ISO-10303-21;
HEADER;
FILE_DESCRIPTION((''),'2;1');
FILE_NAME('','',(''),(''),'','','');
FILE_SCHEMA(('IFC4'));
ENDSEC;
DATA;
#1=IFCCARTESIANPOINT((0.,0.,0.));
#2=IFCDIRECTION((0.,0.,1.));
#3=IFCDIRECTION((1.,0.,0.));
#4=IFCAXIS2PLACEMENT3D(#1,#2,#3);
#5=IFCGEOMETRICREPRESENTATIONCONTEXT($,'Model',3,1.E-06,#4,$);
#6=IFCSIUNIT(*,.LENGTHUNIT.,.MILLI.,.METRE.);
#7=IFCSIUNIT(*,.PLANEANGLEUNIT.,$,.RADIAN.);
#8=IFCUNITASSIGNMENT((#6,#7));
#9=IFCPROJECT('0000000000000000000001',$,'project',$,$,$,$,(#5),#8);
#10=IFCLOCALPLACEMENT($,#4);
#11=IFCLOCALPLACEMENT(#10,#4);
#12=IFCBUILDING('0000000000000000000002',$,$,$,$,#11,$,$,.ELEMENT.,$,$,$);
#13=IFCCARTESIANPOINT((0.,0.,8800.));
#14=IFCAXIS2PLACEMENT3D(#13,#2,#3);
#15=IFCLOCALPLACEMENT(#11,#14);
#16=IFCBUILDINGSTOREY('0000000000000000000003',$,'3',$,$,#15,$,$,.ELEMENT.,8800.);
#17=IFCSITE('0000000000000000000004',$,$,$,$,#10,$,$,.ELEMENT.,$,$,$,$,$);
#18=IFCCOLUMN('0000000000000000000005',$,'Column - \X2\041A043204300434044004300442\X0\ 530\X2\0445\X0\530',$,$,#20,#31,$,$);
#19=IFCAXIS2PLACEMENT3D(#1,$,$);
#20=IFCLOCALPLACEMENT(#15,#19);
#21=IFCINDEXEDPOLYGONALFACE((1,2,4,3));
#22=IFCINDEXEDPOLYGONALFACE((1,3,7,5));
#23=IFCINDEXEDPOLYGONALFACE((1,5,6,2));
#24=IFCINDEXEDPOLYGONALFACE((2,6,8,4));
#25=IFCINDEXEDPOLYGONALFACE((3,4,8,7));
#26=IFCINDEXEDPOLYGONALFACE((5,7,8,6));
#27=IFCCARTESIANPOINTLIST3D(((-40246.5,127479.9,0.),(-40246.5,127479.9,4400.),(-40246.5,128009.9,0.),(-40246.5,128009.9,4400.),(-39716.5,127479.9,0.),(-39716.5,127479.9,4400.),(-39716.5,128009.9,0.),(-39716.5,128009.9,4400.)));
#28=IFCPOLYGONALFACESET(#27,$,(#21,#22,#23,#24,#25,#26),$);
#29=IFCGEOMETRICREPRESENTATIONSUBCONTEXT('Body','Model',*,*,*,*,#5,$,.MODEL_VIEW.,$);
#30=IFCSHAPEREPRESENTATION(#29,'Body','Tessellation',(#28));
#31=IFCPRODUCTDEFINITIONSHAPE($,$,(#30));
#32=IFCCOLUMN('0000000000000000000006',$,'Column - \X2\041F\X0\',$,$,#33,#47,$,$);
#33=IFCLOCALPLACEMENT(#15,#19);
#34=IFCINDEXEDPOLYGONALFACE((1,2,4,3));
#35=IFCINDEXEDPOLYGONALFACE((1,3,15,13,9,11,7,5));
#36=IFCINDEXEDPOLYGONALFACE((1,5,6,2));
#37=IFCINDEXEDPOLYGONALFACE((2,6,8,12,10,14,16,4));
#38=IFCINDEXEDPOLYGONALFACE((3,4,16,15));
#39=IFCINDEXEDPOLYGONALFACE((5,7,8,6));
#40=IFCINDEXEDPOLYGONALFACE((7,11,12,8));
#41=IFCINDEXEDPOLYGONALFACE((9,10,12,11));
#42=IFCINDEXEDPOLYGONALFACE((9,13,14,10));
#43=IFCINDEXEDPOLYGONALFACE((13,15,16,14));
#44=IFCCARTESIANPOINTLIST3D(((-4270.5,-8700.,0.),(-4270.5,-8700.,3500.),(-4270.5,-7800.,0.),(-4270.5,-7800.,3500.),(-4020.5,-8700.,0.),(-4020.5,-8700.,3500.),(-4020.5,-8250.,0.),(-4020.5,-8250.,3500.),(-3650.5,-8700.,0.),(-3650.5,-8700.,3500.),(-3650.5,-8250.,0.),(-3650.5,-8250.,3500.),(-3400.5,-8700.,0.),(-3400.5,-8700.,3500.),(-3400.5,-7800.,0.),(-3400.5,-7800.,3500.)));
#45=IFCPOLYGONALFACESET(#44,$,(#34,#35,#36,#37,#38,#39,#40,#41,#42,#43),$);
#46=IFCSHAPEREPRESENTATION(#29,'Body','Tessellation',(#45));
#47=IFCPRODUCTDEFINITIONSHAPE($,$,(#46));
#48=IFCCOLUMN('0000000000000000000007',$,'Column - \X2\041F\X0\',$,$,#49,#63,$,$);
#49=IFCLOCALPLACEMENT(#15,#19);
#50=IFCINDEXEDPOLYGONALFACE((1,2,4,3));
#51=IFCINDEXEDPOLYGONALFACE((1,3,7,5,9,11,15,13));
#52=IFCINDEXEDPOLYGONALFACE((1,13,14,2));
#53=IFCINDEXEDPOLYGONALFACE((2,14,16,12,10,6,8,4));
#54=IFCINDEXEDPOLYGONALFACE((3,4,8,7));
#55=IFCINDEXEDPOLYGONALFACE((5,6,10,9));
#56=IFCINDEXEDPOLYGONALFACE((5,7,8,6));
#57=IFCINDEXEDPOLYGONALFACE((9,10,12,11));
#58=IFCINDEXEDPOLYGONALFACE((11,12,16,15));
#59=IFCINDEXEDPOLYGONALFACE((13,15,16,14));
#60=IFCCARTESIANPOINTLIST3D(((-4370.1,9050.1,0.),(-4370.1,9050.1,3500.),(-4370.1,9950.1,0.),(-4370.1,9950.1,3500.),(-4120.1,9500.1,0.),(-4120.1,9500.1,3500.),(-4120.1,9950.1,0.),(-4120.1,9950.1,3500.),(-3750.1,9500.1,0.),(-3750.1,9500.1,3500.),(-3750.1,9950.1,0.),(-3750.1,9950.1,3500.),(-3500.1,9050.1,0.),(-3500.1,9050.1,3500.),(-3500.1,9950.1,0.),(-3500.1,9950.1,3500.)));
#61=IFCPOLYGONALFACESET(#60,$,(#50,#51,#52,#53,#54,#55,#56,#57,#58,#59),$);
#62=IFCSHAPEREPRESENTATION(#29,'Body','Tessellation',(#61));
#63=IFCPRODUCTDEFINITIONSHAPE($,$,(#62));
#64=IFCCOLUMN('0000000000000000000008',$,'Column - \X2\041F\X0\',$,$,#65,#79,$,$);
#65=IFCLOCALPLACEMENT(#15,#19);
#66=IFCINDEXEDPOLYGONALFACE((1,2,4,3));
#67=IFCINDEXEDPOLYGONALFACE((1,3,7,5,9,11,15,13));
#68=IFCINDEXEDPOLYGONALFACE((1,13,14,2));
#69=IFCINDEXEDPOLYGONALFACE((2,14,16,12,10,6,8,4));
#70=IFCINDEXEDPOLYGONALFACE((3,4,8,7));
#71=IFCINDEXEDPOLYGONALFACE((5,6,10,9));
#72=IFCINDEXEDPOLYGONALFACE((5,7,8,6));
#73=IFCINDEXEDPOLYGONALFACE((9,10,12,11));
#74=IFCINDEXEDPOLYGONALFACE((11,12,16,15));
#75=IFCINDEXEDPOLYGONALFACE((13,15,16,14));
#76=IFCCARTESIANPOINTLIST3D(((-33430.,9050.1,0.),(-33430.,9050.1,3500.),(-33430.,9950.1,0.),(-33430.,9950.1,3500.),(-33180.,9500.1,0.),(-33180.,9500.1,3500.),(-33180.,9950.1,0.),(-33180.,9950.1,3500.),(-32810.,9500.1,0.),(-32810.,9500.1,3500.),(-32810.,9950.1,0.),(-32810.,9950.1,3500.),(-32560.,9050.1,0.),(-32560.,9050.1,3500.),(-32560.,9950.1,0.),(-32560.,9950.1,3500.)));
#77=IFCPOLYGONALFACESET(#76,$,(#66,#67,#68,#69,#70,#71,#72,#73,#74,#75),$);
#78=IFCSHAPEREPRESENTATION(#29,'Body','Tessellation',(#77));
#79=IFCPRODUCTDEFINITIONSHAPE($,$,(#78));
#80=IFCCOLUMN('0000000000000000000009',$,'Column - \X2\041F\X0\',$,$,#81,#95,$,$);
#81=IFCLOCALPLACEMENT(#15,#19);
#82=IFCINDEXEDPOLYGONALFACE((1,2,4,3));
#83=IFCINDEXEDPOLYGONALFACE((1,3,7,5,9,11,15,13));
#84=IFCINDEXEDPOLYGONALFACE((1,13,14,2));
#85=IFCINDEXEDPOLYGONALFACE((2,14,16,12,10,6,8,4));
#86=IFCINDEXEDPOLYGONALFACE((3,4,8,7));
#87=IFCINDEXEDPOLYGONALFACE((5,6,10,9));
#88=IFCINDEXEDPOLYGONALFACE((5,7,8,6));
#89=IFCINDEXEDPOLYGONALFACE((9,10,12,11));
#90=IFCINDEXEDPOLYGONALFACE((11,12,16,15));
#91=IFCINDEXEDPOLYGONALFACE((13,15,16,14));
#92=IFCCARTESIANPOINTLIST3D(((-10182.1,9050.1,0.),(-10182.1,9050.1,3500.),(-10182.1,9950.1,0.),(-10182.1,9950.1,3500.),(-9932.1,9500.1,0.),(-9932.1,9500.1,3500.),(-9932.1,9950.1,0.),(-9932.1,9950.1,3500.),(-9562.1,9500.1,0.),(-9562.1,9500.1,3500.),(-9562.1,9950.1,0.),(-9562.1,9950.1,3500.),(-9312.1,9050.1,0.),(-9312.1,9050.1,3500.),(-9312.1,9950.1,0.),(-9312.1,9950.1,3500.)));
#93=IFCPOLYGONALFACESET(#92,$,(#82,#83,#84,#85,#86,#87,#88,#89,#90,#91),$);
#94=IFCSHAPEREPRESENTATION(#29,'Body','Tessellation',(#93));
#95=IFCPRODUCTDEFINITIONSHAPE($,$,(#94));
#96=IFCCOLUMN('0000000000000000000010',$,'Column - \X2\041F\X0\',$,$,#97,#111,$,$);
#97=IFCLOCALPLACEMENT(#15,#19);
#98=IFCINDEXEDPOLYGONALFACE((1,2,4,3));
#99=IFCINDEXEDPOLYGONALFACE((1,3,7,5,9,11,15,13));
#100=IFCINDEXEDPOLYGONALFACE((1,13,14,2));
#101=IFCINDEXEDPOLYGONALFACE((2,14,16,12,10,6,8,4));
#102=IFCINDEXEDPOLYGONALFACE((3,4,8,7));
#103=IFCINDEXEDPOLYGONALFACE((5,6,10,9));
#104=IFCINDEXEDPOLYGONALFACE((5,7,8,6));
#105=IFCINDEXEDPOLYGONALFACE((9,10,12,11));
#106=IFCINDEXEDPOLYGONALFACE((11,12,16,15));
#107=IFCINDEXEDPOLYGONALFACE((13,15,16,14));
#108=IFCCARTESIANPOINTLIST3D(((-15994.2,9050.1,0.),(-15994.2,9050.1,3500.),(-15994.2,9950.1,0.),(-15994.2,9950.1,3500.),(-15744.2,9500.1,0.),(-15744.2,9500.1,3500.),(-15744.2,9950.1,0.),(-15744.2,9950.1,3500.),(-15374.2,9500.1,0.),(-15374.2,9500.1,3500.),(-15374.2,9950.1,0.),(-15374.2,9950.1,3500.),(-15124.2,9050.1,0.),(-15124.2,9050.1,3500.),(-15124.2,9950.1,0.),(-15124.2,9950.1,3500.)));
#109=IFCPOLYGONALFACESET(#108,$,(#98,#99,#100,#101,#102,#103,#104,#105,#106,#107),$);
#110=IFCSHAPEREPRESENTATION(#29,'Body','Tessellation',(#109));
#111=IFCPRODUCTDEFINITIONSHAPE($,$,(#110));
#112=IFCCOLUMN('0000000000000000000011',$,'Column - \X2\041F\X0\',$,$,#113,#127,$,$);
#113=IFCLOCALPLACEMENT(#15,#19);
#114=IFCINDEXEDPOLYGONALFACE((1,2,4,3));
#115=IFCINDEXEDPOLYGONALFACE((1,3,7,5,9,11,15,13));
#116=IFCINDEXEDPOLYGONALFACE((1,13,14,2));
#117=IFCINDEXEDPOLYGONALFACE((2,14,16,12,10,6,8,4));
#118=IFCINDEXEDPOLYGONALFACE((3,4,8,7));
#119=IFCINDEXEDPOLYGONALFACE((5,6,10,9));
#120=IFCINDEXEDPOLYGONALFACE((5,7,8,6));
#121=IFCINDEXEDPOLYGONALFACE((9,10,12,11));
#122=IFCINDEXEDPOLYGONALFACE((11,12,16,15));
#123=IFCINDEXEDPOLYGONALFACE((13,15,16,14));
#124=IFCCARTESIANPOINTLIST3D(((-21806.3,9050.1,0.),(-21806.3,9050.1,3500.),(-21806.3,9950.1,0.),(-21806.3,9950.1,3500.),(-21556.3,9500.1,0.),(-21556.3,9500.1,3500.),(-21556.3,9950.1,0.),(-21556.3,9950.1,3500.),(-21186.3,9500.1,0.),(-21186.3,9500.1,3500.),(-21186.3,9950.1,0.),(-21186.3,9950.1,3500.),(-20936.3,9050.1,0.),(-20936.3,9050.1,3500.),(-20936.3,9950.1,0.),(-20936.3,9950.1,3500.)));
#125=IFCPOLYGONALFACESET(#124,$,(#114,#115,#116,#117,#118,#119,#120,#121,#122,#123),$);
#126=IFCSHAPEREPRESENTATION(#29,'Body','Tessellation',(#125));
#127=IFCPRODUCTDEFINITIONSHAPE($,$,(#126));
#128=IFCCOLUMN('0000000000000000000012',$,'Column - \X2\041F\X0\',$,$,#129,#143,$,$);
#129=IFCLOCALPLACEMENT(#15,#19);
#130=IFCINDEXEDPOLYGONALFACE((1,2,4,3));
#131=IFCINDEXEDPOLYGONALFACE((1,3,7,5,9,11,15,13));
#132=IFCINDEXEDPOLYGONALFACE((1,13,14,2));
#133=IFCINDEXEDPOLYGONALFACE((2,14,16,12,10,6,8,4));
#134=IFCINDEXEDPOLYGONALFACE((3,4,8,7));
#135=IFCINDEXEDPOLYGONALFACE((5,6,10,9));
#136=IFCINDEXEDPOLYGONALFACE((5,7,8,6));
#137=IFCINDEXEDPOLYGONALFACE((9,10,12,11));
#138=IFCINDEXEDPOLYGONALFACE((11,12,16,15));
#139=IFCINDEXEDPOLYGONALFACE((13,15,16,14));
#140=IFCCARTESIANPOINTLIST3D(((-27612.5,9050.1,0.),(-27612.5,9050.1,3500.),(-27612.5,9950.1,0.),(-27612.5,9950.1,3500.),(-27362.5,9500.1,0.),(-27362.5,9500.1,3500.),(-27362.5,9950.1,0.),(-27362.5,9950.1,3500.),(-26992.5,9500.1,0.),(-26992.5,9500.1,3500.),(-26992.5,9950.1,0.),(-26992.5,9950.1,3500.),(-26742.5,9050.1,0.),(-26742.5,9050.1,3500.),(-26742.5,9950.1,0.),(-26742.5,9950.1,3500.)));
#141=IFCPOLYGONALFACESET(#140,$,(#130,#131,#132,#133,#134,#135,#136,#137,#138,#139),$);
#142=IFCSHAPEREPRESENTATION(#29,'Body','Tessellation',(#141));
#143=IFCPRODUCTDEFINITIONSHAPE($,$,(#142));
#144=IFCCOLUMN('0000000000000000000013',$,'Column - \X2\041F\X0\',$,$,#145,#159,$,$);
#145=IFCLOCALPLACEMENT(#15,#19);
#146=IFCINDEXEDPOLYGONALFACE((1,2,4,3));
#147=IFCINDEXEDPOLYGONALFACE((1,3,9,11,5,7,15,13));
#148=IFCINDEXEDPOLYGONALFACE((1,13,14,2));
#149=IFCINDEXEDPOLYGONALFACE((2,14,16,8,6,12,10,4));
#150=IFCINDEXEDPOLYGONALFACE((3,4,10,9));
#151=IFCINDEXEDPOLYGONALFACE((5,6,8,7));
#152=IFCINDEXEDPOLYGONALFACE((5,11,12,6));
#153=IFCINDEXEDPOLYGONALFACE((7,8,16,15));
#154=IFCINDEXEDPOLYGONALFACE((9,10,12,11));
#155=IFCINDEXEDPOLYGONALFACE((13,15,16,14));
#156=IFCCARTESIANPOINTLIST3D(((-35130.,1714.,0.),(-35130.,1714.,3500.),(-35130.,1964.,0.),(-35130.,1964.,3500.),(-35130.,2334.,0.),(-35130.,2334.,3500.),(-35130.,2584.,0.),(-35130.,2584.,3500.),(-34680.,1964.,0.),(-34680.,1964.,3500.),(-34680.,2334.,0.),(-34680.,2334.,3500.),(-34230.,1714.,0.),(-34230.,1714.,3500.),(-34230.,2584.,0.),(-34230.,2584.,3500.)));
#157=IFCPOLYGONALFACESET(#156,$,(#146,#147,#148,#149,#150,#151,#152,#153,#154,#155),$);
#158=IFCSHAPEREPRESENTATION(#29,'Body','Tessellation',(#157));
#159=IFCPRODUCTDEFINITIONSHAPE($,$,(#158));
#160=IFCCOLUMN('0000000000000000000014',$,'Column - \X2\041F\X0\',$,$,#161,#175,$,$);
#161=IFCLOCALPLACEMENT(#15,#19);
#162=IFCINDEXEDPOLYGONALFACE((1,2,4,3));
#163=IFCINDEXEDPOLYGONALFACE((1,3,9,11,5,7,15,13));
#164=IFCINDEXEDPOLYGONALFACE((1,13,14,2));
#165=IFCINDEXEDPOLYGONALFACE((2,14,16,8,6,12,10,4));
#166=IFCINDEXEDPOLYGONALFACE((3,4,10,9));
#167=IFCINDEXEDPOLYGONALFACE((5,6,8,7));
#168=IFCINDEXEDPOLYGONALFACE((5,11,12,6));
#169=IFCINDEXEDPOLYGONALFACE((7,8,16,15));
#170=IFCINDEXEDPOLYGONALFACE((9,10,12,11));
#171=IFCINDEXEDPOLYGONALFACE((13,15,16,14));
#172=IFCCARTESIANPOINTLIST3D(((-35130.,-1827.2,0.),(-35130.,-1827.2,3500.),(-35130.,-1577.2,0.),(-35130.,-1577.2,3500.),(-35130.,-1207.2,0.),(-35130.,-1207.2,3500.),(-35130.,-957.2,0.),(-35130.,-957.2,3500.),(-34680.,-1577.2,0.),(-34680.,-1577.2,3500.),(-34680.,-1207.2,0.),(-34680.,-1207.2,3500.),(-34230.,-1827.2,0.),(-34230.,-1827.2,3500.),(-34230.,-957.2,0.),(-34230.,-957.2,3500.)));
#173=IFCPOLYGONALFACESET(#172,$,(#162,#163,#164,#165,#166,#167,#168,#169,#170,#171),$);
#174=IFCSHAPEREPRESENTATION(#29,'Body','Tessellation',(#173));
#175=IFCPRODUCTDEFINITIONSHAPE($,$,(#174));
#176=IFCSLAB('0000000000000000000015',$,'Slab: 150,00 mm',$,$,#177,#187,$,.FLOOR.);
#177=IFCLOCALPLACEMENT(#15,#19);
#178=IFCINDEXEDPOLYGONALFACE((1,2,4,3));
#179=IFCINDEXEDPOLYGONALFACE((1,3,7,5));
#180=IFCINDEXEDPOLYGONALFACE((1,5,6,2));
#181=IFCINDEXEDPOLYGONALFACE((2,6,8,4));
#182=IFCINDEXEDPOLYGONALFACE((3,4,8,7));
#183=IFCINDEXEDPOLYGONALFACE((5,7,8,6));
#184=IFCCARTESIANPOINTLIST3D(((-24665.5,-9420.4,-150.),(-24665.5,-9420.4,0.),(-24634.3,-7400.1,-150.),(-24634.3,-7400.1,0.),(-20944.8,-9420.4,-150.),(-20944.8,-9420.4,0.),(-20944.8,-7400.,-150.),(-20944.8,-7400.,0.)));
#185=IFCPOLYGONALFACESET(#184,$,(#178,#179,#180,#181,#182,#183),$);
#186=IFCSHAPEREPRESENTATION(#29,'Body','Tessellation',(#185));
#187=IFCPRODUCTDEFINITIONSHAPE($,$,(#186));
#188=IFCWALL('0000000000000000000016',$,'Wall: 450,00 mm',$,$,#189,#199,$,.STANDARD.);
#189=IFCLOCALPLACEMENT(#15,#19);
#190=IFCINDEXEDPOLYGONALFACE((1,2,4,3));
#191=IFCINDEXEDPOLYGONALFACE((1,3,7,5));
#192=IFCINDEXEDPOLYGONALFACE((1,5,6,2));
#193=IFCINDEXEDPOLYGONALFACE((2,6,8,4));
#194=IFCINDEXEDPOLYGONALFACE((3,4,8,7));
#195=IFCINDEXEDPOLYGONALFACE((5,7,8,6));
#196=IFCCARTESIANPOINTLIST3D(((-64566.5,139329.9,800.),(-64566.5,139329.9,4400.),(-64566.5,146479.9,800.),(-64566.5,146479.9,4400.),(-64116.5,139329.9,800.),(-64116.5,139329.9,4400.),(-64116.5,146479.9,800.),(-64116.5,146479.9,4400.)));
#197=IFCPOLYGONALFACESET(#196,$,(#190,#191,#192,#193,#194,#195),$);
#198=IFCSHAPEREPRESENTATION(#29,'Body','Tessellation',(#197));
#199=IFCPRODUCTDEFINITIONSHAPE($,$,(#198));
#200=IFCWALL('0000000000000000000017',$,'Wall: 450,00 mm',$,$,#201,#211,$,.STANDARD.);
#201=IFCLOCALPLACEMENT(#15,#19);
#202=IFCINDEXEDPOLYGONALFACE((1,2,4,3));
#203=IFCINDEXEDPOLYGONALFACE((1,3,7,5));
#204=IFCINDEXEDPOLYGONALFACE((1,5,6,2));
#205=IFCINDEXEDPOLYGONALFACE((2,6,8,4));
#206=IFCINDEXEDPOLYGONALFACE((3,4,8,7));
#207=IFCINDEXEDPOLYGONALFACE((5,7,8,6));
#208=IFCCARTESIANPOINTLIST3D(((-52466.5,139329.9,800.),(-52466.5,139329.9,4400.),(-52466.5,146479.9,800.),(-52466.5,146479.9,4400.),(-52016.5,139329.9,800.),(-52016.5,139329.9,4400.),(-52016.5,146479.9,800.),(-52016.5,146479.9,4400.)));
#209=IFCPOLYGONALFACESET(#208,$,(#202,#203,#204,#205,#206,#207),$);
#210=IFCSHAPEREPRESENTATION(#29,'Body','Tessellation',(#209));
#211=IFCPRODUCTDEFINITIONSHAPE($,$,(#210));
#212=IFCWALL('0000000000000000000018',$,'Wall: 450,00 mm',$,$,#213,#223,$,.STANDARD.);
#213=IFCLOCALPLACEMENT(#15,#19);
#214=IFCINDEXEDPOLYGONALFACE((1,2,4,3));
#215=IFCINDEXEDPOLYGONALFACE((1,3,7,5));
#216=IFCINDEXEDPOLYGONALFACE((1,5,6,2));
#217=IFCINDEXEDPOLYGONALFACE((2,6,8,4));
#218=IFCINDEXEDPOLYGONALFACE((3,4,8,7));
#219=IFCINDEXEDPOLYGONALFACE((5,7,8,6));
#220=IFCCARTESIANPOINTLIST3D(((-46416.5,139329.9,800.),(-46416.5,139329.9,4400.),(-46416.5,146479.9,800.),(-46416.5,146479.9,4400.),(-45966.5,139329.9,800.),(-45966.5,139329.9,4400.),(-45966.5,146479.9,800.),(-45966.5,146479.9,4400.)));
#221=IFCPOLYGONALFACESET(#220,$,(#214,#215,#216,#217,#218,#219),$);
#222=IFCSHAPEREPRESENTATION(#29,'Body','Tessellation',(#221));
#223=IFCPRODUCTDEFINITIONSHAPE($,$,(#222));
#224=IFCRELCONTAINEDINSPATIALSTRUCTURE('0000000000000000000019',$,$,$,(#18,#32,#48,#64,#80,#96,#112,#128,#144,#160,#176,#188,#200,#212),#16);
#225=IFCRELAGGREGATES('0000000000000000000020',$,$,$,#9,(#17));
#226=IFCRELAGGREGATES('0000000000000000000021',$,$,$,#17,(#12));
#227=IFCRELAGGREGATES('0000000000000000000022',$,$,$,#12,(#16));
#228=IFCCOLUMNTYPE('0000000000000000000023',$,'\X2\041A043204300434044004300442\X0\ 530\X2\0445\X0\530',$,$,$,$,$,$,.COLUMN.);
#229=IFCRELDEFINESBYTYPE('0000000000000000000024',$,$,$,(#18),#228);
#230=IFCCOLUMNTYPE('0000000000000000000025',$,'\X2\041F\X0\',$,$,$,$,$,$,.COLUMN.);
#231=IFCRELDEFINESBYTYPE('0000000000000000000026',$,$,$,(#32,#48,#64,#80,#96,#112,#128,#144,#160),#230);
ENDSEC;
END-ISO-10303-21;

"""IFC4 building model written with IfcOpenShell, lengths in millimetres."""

from ifc_helpers import new_model, si_unit, frame, origin_with_axes, place, context, subcontext, project, spatial, line, indexed_curve, outline, extrude, source, transform, mapped, type_object, element, save


model = new_model("IFC4")

# Units and contexts
model_context = context("Model", 3, precision=1e-06, world=origin_with_axes())
body_context = subcontext(model_context, "Body", "Model", "MODEL_VIEW")
ifc_project = project(units=[si_unit("LENGTHUNIT", "METRE", prefix="MILLI"), si_unit("PLANEANGLEUNIT", "RADIAN")], contexts=[model_context])

# Site, building, storey
site_placement = place(None, origin_with_axes())
site = spatial("IfcSite", under=ifc_project, at=site_placement, CompositionType="ELEMENT")
building_placement = place(site_placement, origin_with_axes())
building = spatial("IfcBuilding", under=site, at=building_placement, CompositionType="ELEMENT")
storey_placement = place(building_placement, frame((0.0, 0.0, 8800.0), z_axis=(0.0, 0.0, 1.0), x_axis=(1.0, 0.0, 0.0)))
storey = spatial("IfcBuildingStorey", under=building, at=storey_placement, Name="3", CompositionType="ELEMENT", Elevation=8800.0)

# Columns
column_type_1 = type_object("IfcColumnType", Name="Квадрат 530х530", PredefinedType="COLUMN")
shared_shape_1 = source(origin_with_axes(), body_context, "Body", "SweptSolid", [
    extrude(outline(indexed_curve([(-265.0, -265.0), (265.0, -265.0), (265.0, 265.0), (-265.0, 265.0)], segments=[line(1, 2), line(2, 3), line(3, 4), line(4, 1)])), origin_with_axes(), (0.0, 0.0, 1.0), 4400.0),
])
column_placement = place(storey_placement, frame((-39981.5, 127744.9, 0.0), z_axis=(0.0, 0.0, 1.0), x_axis=(1.0, 0.0, 0.0)))
element("IfcColumn", 1, at=column_placement, inside=storey, type_object=column_type_1, Name="Column - Квадрат 530х530", context=body_context, shape_type="MappedRepresentation", body=[
    mapped(shared_shape_1, transform((0.0, 0.0, 0.0), x_axis=(1.0, 0.0, 0.0), y_axis=(0.0, 1.0, 0.0), z_axis=(0.0, 0.0, 1.0), scale=1.0)),
])
column_type_2 = type_object("IfcColumnType", Name="П", PredefinedType="COLUMN")
shared_shape_2 = source(origin_with_axes(), body_context, "Body", "SweptSolid", [
    extrude(outline(indexed_curve([(-450.0, -435.0), (450.0, -435.0), (450.0, -185.0), (0.0, -185.0), (0.0, 185.0), (450.0, 185.0), (450.0, 435.0), (-450.0, 435.0)], segments=[line(1, 2), line(2, 3), line(3, 4), line(4, 5), line(5, 6), line(6, 7), line(7, 8), line(8, 1)])), origin_with_axes(), (0.0, 0.0, 1.0), 3500.0),
])
for number, where, z_axis, x_axis, name in (
    (2, (-3835.5, -8250.0, 0.0), (0.0, 0.0, 1.0), (0.0, -1.0, 0.0), "Column - П"),
    (3, (-3935.1, 9500.1, 0.0), (0.0, 0.0, 1.0), (0.0, 1.0, 0.0), "Column - П"),
    (4, (-32995.0, 9500.1, 0.0), (0.0, 0.0, 1.0), (0.0, 1.0, 0.0), "Column - П"),
    (5, (-9747.1, 9500.1, 0.0), (0.0, 0.0, 1.0), (0.0, 1.0, 0.0), "Column - П"),
    (6, (-15559.2, 9500.1, 0.0), (0.0, 0.0, 1.0), (0.0, 1.0, 0.0), "Column - П"),
    (7, (-21371.3, 9500.1, 0.0), (0.0, 0.0, 1.0), (0.0, 1.0, 0.0), "Column - П"),
    (8, (-27177.5, 9500.1, 0.0), (0.0, 0.0, 1.0), (0.0, 1.0, 0.0), "Column - П"),
    (9, (-34680.0, 2149.0, 0.0), (0.0, 0.0, 1.0), (-1.0, 0.0, 0.0), "Column - П"),
    (10, (-34680.0, -1392.2, 0.0), (0.0, 0.0, 1.0), (-1.0, 0.0, 0.0), "Column - П"),
):
    element("IfcColumn", number, at=place(storey_placement, frame(where, z_axis=z_axis, x_axis=x_axis)), inside=storey, type_object=column_type_2, Name=name, context=body_context, shape_type="MappedRepresentation", body=[
        mapped(shared_shape_2, transform((0.0, 0.0, 0.0), x_axis=(1.0, 0.0, 0.0), y_axis=(0.0, 1.0, 0.0), z_axis=(0.0, 0.0, 1.0), scale=1.0)),
    ])

# Slab
slab_placement = place(storey_placement, frame((-24634.3, -7400.1, -150.0), z_axis=(0.0, 0.0, 1.0), x_axis=(-0.015431, -0.999881, 0.0)))
element("IfcSlab", 11, at=slab_placement, inside=storey, Name="Slab: 150,00 mm", PredefinedType="FLOOR", context=body_context, shape_type="SweptSolid", body=[
    extrude(outline(indexed_curve([(0.0, 0.0), (2020.5, 0.0), (1963.1, 3720.2), (-57.0, 3689.1)], segments=[line(1, 2), line(2, 3), line(3, 4), line(4, 1)])), origin_with_axes(), (0.0, 0.0, 1.0), 150.0),
])

# Walls
for number, where, z_axis, x_axis, name in (
    (12, (-64566.5, 139329.9, 800.0), (0.0, 0.0, 1.0), (0.0, 1.0, 0.0), "Wall: 450,00 mm"),
    (13, (-52466.5, 139329.9, 800.0), (0.0, 0.0, 1.0), (0.0, 1.0, 0.0), "Wall: 450,00 mm"),
    (14, (-46416.5, 139329.9, 800.0), (0.0, 0.0, 1.0), (0.0, 1.0, 0.0), "Wall: 450,00 mm"),
):
    element("IfcWall", number, at=place(storey_placement, frame(where, z_axis=z_axis, x_axis=x_axis)), inside=storey, Name=name, PredefinedType="STANDARD", context=body_context, shape_type="SweptSolid", body=[
        extrude(outline(indexed_curve([(0.0, -450.0), (7150.0, -450.0), (7150.0, 0.0), (0.0, 0.0)], segments=[line(1, 2), line(2, 3), line(3, 4), line(4, 1)])), origin_with_axes(), (0.0, 0.0, 1.0), 3600.0),
    ])

save(model, "model.ifc")
